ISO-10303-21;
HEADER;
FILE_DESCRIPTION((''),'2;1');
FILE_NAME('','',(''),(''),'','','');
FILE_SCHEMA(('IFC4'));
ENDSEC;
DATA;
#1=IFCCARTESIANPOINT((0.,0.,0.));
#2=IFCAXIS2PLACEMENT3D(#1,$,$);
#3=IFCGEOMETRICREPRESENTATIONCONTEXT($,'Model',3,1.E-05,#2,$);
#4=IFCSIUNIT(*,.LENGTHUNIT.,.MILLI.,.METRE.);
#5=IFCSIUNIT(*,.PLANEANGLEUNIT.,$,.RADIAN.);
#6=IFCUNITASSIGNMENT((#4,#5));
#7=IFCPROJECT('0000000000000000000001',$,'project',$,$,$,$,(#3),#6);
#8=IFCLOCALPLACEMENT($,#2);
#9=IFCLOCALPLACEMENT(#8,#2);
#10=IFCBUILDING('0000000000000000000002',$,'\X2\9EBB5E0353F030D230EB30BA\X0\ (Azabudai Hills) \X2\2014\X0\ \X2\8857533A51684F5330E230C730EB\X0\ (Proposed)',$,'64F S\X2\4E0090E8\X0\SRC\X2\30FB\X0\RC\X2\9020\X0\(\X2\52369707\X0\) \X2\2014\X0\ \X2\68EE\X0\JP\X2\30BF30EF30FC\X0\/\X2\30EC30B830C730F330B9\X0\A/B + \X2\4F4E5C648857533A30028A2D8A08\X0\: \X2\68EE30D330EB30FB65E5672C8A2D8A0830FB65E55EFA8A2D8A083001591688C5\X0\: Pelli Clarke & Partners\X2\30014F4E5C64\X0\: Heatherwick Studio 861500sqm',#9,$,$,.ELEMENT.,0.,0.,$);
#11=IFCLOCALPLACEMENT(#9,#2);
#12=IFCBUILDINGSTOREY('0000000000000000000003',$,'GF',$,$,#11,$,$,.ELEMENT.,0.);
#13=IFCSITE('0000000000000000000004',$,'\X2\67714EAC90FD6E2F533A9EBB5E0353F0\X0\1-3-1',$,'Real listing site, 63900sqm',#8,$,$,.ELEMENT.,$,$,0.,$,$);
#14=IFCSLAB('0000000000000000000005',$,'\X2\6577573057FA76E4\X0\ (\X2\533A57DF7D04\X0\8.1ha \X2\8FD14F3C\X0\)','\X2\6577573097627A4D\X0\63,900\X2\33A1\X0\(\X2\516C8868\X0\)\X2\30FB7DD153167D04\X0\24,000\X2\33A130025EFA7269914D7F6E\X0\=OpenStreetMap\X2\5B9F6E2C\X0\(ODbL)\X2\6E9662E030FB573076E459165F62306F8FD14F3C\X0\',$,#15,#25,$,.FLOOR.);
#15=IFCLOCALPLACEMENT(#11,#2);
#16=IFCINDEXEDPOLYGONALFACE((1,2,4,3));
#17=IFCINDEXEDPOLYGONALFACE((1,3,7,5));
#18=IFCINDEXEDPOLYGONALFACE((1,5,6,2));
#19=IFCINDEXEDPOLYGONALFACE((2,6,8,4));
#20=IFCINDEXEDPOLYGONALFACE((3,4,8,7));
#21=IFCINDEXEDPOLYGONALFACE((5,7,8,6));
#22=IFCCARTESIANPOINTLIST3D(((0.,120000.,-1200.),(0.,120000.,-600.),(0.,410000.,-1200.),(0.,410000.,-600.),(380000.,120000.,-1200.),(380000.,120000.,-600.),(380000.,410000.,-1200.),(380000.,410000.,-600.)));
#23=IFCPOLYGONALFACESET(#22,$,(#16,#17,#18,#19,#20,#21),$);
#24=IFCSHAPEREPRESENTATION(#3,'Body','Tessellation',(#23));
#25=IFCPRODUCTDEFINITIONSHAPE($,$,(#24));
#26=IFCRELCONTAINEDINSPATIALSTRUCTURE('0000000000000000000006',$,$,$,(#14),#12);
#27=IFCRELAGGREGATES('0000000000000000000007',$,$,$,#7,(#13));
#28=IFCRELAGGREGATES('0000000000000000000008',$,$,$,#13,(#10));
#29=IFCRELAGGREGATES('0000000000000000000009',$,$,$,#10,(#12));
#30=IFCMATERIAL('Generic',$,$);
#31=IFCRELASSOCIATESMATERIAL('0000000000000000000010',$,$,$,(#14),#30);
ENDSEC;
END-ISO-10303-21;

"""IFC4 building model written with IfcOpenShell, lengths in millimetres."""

from ifc_helpers import new_model, si_unit, frame, frame_2d, origin, place, context, project, spatial, rectangle, extrude, material, element, save


model = new_model("IFC4")

# Units and contexts
model_context = context("Model", 3, precision=1e-05, world=origin())
ifc_project = project(units=[si_unit("LENGTHUNIT", "METRE", prefix="MILLI"), si_unit("PLANEANGLEUNIT", "RADIAN")], contexts=[model_context])

# Site, building, storey
site_placement = place(None, origin())
site = spatial("IfcSite", under=ifc_project, at=site_placement, Name="東京都港区麻布台1-3-1", ObjectType="Real listing site, 63900sqm", CompositionType="ELEMENT", RefElevation=0.0)
building_placement = place(site_placement, origin())
building = spatial("IfcBuilding", under=site, at=building_placement, Name="麻布台ヒルズ (Azabudai Hills) — 街区全体モデル (Proposed)", ObjectType="64F S一部SRC・RC造(制震) — 森JPタワー/レジデンスA/B + 低層街区。設計: 森ビル・日本設計・日建設計、外装: Pelli Clarke & Partners、低層: Heatherwick Studio 861500sqm", CompositionType="ELEMENT", ElevationOfRefHeight=0.0, ElevationOfTerrain=0.0)
storey_placement = place(building_placement, origin())
storey = spatial("IfcBuildingStorey", under=building, at=storey_placement, Name="GF", CompositionType="ELEMENT", Elevation=0.0)

# Slab
ifc_material = material(Name="Generic")
slab_1_placement = place(storey_placement, frame((0.0, 60000.0, -600.0)))
element("IfcSlab", 1, at=slab_1_placement, inside=storey, material=ifc_material, Name="敷地基盤 (区域約8.1ha 近似)", Description="敷地面積63,900㎡(公表)・緑化約24,000㎡。建物配置=OpenStreetMap実測(ODbL)準拠・地盤外形は近似", PredefinedType="FLOOR", context=model_context, shape_type="SweptSolid", body=[
    extrude(rectangle(XDim=380000.0, YDim=290000.0, at=frame_2d((190000.0, 145000.0))), frame((0.0, 60000.0, -600.0)), (0.0, 0.0, 1.0), 600.0),
])

save(model, "model.ifc")
